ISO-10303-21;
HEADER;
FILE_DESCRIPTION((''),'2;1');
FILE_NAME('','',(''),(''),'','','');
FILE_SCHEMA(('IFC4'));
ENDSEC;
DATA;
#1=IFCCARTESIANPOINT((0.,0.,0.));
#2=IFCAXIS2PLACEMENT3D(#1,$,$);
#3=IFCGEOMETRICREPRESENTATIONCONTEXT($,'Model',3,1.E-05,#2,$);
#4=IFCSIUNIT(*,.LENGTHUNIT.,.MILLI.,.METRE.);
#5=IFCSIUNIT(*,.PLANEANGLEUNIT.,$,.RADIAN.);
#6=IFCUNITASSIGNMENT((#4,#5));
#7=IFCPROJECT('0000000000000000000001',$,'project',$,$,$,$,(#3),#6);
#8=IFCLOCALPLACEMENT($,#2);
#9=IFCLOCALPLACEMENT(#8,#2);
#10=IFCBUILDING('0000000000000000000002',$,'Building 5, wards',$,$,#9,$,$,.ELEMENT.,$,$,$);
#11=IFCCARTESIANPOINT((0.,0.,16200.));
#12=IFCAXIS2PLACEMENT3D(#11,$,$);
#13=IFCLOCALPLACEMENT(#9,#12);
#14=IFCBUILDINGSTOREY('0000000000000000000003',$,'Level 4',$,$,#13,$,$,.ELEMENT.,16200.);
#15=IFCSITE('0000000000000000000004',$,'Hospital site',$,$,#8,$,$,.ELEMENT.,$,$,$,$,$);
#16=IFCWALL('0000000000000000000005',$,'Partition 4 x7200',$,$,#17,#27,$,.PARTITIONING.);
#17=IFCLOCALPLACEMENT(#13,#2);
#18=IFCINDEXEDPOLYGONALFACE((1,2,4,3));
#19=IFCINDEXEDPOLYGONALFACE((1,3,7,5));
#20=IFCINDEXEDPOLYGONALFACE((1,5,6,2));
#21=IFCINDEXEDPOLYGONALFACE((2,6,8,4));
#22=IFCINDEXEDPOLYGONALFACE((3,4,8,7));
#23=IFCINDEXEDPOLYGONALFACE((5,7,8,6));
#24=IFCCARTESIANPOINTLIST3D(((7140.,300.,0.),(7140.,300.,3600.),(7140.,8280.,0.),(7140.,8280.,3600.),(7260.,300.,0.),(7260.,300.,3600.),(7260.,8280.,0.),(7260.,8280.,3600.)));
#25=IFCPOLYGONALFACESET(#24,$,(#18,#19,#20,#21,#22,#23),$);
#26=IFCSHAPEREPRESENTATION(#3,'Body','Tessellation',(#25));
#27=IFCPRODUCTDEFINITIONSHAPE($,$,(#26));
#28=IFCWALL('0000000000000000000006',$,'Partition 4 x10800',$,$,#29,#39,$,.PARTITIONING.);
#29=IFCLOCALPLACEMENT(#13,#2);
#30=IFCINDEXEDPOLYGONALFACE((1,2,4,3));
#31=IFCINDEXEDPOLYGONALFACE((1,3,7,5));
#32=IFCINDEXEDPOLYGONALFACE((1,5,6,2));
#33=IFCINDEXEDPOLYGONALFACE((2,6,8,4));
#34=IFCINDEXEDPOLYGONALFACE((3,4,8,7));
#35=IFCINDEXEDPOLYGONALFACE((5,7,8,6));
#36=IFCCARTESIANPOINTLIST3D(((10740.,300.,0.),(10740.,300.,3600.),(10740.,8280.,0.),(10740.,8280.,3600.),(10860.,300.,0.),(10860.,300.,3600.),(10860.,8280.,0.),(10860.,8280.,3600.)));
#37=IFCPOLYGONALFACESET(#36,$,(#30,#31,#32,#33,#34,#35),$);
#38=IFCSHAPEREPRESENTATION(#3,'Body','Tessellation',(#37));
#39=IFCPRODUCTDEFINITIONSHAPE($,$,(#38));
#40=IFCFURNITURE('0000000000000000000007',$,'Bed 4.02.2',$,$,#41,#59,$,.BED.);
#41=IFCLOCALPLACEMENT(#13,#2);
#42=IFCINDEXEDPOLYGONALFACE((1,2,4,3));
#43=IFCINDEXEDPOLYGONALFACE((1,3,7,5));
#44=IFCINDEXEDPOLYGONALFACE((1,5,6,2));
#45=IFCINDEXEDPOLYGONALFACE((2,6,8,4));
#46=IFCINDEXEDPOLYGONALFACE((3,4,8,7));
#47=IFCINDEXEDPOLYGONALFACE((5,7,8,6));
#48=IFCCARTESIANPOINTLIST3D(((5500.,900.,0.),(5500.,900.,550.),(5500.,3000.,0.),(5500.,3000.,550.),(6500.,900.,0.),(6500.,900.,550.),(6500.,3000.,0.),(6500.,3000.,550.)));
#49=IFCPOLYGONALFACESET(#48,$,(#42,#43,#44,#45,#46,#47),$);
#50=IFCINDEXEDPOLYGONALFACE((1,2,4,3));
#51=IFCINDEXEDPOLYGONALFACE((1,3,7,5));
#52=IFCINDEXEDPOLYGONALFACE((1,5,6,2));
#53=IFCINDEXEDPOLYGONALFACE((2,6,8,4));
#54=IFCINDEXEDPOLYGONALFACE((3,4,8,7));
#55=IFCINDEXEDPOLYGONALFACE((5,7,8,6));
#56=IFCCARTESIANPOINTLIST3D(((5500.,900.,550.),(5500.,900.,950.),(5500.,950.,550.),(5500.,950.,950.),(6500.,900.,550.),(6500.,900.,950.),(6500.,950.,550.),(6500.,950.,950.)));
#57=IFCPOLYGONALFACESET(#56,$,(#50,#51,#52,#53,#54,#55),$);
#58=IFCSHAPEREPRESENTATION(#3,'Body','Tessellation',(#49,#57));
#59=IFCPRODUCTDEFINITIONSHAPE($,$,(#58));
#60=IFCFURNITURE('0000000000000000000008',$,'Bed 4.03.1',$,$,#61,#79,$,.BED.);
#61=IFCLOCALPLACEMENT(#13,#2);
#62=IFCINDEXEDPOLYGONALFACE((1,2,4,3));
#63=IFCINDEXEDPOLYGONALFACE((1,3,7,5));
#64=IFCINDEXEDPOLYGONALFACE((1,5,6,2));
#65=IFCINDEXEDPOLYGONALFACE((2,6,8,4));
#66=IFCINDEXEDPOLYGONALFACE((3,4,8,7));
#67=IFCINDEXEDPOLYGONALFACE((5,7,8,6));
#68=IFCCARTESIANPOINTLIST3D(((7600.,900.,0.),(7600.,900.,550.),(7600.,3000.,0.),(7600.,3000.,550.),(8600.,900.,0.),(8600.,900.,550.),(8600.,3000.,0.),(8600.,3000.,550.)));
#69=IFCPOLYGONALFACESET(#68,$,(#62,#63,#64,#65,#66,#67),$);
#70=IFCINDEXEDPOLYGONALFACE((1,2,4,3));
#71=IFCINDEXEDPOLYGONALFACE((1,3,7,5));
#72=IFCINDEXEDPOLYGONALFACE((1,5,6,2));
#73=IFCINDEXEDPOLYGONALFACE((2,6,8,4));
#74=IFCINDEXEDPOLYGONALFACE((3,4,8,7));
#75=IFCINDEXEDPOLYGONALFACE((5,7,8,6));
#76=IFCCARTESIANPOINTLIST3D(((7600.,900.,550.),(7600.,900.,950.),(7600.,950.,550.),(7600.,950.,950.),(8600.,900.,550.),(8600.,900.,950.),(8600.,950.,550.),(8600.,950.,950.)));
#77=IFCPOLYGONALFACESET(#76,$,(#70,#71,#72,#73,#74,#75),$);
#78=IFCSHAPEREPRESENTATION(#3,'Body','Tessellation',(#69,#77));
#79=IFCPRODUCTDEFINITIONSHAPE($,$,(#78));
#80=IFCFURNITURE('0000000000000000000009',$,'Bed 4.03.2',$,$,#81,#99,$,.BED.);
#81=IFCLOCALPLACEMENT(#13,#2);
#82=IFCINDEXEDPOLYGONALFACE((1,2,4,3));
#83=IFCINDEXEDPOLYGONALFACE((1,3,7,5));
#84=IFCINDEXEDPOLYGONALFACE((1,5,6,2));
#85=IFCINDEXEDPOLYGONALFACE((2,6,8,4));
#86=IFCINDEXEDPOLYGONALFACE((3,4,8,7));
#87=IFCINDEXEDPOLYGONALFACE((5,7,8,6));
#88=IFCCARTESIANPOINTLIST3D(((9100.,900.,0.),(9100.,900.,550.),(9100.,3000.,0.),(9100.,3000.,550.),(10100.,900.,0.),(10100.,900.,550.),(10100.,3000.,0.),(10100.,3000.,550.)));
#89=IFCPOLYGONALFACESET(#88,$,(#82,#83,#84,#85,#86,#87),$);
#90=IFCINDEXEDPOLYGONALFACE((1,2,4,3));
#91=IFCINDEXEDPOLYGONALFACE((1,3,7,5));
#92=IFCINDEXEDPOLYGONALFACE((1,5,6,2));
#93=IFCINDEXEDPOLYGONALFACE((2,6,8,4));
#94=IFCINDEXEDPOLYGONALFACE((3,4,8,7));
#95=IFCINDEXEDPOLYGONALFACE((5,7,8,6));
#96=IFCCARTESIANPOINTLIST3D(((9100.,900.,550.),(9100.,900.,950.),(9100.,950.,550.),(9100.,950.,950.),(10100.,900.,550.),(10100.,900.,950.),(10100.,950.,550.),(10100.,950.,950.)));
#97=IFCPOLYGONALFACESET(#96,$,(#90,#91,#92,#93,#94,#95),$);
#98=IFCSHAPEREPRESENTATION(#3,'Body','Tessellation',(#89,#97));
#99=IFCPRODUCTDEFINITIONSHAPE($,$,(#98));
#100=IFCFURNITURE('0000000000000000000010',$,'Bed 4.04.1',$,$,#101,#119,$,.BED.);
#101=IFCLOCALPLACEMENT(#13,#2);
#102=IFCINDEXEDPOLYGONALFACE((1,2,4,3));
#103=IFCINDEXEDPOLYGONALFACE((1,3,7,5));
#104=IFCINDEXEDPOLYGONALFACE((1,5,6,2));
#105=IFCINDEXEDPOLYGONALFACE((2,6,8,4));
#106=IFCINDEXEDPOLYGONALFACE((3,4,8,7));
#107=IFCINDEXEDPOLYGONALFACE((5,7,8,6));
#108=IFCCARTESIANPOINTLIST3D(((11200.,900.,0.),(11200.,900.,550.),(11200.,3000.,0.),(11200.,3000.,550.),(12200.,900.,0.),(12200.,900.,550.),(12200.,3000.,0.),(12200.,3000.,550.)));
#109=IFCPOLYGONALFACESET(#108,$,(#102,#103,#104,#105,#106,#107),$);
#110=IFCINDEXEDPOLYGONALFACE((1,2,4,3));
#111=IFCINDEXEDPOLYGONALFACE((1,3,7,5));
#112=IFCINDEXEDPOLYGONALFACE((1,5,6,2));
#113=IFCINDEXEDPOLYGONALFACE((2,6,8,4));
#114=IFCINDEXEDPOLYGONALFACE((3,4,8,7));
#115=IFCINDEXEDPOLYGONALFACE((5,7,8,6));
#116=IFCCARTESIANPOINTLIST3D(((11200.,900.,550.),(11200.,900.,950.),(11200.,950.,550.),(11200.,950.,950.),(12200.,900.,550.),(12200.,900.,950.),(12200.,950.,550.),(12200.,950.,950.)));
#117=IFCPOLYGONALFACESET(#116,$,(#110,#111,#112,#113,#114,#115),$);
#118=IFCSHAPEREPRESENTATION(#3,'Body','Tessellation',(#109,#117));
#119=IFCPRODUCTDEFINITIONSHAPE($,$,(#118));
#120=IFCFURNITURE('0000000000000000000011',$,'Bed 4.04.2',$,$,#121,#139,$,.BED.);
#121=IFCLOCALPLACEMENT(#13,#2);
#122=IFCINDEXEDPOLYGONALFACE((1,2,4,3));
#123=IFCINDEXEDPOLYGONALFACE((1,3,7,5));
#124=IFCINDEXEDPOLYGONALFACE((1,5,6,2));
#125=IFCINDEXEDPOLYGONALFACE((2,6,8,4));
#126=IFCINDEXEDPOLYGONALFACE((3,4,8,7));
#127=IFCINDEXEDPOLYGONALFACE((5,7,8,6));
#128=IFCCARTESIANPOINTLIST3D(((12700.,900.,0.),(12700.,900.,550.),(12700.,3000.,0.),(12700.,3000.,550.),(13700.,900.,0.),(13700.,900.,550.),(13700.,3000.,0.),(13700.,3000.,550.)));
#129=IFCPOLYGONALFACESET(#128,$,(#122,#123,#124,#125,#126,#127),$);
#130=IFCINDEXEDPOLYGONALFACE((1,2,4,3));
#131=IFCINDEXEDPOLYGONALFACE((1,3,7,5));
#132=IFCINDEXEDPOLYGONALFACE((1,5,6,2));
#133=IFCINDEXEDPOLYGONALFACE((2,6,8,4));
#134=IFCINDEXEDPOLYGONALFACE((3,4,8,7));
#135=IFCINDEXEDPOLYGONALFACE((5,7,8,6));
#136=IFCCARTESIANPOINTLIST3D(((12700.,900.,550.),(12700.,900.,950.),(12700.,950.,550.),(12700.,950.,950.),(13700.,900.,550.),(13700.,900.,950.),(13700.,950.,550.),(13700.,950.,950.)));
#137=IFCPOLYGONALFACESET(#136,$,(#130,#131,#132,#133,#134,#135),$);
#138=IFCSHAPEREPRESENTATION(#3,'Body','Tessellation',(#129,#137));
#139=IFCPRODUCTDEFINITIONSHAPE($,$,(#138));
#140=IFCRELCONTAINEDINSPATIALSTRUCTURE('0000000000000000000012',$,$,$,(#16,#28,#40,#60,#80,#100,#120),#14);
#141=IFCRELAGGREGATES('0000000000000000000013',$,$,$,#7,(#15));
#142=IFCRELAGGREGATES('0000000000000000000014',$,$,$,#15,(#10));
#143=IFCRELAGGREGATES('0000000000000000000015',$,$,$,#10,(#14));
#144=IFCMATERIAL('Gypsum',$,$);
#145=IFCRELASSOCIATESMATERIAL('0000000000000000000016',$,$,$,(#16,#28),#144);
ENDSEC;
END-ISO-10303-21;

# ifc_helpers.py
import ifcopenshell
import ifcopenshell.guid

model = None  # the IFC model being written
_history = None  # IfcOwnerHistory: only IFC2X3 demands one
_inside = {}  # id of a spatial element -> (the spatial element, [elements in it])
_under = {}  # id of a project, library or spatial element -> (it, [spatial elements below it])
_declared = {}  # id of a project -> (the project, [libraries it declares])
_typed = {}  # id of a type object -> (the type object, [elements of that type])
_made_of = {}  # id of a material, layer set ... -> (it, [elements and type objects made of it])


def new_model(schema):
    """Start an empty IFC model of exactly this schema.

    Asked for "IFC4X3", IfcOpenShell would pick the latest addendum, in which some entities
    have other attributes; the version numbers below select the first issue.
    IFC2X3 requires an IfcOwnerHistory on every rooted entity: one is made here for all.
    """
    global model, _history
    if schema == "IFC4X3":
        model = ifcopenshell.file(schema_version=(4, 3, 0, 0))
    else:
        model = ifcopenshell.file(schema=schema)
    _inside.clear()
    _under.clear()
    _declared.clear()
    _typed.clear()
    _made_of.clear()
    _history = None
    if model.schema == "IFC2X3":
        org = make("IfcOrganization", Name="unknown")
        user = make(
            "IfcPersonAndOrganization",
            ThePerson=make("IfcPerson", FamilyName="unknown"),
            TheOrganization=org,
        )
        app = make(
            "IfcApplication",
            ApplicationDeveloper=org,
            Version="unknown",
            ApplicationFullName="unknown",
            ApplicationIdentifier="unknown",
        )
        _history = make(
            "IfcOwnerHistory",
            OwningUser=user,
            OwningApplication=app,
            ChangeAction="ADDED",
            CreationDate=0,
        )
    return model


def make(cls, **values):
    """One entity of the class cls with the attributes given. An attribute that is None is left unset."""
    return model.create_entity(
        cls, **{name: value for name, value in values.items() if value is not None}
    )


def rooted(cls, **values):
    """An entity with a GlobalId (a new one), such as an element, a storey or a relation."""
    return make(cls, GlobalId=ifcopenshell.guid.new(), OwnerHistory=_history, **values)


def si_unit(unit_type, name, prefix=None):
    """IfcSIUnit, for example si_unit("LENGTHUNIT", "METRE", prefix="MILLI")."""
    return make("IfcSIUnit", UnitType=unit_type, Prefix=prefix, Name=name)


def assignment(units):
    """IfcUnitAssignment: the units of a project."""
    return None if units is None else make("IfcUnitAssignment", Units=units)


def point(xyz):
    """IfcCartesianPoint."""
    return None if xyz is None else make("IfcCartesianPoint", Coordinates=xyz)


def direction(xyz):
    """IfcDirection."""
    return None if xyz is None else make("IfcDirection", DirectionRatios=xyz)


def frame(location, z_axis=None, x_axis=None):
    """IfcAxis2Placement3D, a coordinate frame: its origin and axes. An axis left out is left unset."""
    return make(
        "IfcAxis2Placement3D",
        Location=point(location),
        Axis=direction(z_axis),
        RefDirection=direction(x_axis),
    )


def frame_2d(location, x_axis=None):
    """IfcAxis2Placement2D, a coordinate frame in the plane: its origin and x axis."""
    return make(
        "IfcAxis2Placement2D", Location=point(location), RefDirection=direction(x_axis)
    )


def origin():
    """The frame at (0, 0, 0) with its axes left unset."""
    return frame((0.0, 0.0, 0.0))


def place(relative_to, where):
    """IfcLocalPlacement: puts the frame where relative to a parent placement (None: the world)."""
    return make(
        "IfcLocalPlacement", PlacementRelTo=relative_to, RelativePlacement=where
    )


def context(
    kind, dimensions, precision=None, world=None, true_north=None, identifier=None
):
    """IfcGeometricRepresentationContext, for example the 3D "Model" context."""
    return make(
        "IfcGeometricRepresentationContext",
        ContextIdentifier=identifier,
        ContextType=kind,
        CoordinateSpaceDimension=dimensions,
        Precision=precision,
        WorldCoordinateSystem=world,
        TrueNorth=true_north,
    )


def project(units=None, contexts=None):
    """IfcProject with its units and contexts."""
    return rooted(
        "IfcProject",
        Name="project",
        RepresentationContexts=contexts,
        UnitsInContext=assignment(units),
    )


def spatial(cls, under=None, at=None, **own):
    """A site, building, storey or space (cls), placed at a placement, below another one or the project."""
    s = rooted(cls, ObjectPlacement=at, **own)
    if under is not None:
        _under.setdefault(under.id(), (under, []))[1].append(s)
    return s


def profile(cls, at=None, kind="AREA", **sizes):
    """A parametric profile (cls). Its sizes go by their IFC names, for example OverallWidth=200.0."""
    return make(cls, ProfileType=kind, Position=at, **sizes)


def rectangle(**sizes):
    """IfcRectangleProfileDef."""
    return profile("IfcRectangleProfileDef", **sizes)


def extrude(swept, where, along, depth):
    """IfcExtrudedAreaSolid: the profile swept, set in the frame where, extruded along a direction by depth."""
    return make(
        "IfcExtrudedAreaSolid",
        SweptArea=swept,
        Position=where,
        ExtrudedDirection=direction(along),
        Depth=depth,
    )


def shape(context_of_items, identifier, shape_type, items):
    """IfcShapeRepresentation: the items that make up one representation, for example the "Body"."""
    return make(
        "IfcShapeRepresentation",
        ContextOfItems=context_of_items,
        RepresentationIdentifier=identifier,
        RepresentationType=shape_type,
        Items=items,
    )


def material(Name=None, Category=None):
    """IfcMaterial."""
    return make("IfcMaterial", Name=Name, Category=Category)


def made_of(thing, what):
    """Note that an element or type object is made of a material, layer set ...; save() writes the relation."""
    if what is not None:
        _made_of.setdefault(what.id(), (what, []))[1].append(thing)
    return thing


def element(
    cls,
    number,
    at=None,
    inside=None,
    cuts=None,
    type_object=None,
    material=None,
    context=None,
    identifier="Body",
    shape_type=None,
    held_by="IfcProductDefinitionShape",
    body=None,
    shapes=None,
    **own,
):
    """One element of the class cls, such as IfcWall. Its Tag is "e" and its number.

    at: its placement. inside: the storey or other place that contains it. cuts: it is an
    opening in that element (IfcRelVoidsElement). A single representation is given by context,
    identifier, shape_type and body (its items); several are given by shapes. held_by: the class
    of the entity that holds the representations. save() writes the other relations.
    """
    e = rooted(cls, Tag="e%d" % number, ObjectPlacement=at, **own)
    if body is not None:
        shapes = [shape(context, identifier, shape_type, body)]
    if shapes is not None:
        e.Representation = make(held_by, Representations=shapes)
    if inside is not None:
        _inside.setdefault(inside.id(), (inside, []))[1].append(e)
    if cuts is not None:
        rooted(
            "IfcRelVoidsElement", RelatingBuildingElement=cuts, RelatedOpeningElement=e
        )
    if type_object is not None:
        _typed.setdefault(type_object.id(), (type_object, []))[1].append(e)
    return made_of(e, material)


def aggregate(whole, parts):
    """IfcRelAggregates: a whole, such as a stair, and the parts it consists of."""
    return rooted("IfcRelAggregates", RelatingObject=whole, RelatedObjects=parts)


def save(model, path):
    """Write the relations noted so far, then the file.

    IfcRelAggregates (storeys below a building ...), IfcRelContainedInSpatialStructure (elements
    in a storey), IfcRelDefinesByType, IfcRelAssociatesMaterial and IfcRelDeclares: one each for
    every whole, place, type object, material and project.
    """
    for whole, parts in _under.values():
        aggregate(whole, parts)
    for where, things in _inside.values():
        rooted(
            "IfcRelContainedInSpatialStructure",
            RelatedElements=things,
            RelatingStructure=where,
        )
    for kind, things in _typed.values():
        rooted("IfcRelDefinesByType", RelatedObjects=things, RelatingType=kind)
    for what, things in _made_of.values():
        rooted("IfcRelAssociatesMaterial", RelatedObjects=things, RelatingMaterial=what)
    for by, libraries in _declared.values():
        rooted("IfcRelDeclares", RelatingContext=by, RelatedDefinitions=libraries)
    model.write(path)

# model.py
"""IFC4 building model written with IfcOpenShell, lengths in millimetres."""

from ifc_helpers import new_model, si_unit, frame, frame_2d, origin, place, context, project, spatial, rectangle, extrude, material, element, save


model = new_model("IFC4")

# Units and contexts
model_context = context("Model", 3, precision=1e-05, world=origin())
ifc_project = project(units=[si_unit("LENGTHUNIT", "METRE", prefix="MILLI"), si_unit("PLANEANGLEUNIT", "RADIAN")], contexts=[model_context])

# Site, building, storey
site_placement = place(None, origin())
site = spatial("IfcSite", under=ifc_project, at=site_placement, Name="Hospital site", CompositionType="ELEMENT")
building_placement = place(site_placement, origin())
building = spatial("IfcBuilding", under=site, at=building_placement, Name="Building 5, wards", CompositionType="ELEMENT")
storey_placement = place(building_placement, frame((0.0, 0.0, 16200.0)))
storey = spatial("IfcBuildingStorey", under=building, at=storey_placement, Name="Level 4", CompositionType="ELEMENT", Elevation=16200.0)

# Walls
ifc_material = material(Name="Gypsum")
for number, where, x_axis, name in (
    (1, (7260.0, 300.0, 0.0), (0.0, 1.0, 0.0), "Partition 4 x7200"),
    (2, (10860.0, 300.0, 0.0), (0.0, 1.0, 0.0), "Partition 4 x10800"),
):
    element("IfcWall", number, at=place(storey_placement, frame(where, x_axis=x_axis)), inside=storey, material=ifc_material, Name=name, PredefinedType="PARTITIONING", context=model_context, shape_type="SweptSolid", body=[
        extrude(rectangle(XDim=7980.0, YDim=120.0, at=frame_2d((3990.0, 60.0))), origin(), (0.0, 0.0, 1.0), 3600.0),
    ])

# Furniture
for number, where, name in (
    (3, (5500.0, 900.0, 0.0), "Bed 4.02.2"),
    (4, (7600.0, 900.0, 0.0), "Bed 4.03.1"),
    (5, (9100.0, 900.0, 0.0), "Bed 4.03.2"),
    (6, (11200.0, 900.0, 0.0), "Bed 4.04.1"),
    (7, (12700.0, 900.0, 0.0), "Bed 4.04.2"),
):
    element("IfcFurniture", number, at=place(storey_placement, frame(where)), inside=storey, Name=name, PredefinedType="BED", context=model_context, shape_type="SweptSolid", body=[
        extrude(rectangle(XDim=1000.0, YDim=2100.0, at=frame_2d((500.0, 1050.0))), origin(), (0.0, 0.0, 1.0), 550.0),
        extrude(rectangle(XDim=1000.0, YDim=50.0, at=frame_2d((500.0, 25.0))), frame((0.0, 0.0, 550.0)), (0.0, 0.0, 1.0), 400.0),
    ])

save(model, "model.ifc")
